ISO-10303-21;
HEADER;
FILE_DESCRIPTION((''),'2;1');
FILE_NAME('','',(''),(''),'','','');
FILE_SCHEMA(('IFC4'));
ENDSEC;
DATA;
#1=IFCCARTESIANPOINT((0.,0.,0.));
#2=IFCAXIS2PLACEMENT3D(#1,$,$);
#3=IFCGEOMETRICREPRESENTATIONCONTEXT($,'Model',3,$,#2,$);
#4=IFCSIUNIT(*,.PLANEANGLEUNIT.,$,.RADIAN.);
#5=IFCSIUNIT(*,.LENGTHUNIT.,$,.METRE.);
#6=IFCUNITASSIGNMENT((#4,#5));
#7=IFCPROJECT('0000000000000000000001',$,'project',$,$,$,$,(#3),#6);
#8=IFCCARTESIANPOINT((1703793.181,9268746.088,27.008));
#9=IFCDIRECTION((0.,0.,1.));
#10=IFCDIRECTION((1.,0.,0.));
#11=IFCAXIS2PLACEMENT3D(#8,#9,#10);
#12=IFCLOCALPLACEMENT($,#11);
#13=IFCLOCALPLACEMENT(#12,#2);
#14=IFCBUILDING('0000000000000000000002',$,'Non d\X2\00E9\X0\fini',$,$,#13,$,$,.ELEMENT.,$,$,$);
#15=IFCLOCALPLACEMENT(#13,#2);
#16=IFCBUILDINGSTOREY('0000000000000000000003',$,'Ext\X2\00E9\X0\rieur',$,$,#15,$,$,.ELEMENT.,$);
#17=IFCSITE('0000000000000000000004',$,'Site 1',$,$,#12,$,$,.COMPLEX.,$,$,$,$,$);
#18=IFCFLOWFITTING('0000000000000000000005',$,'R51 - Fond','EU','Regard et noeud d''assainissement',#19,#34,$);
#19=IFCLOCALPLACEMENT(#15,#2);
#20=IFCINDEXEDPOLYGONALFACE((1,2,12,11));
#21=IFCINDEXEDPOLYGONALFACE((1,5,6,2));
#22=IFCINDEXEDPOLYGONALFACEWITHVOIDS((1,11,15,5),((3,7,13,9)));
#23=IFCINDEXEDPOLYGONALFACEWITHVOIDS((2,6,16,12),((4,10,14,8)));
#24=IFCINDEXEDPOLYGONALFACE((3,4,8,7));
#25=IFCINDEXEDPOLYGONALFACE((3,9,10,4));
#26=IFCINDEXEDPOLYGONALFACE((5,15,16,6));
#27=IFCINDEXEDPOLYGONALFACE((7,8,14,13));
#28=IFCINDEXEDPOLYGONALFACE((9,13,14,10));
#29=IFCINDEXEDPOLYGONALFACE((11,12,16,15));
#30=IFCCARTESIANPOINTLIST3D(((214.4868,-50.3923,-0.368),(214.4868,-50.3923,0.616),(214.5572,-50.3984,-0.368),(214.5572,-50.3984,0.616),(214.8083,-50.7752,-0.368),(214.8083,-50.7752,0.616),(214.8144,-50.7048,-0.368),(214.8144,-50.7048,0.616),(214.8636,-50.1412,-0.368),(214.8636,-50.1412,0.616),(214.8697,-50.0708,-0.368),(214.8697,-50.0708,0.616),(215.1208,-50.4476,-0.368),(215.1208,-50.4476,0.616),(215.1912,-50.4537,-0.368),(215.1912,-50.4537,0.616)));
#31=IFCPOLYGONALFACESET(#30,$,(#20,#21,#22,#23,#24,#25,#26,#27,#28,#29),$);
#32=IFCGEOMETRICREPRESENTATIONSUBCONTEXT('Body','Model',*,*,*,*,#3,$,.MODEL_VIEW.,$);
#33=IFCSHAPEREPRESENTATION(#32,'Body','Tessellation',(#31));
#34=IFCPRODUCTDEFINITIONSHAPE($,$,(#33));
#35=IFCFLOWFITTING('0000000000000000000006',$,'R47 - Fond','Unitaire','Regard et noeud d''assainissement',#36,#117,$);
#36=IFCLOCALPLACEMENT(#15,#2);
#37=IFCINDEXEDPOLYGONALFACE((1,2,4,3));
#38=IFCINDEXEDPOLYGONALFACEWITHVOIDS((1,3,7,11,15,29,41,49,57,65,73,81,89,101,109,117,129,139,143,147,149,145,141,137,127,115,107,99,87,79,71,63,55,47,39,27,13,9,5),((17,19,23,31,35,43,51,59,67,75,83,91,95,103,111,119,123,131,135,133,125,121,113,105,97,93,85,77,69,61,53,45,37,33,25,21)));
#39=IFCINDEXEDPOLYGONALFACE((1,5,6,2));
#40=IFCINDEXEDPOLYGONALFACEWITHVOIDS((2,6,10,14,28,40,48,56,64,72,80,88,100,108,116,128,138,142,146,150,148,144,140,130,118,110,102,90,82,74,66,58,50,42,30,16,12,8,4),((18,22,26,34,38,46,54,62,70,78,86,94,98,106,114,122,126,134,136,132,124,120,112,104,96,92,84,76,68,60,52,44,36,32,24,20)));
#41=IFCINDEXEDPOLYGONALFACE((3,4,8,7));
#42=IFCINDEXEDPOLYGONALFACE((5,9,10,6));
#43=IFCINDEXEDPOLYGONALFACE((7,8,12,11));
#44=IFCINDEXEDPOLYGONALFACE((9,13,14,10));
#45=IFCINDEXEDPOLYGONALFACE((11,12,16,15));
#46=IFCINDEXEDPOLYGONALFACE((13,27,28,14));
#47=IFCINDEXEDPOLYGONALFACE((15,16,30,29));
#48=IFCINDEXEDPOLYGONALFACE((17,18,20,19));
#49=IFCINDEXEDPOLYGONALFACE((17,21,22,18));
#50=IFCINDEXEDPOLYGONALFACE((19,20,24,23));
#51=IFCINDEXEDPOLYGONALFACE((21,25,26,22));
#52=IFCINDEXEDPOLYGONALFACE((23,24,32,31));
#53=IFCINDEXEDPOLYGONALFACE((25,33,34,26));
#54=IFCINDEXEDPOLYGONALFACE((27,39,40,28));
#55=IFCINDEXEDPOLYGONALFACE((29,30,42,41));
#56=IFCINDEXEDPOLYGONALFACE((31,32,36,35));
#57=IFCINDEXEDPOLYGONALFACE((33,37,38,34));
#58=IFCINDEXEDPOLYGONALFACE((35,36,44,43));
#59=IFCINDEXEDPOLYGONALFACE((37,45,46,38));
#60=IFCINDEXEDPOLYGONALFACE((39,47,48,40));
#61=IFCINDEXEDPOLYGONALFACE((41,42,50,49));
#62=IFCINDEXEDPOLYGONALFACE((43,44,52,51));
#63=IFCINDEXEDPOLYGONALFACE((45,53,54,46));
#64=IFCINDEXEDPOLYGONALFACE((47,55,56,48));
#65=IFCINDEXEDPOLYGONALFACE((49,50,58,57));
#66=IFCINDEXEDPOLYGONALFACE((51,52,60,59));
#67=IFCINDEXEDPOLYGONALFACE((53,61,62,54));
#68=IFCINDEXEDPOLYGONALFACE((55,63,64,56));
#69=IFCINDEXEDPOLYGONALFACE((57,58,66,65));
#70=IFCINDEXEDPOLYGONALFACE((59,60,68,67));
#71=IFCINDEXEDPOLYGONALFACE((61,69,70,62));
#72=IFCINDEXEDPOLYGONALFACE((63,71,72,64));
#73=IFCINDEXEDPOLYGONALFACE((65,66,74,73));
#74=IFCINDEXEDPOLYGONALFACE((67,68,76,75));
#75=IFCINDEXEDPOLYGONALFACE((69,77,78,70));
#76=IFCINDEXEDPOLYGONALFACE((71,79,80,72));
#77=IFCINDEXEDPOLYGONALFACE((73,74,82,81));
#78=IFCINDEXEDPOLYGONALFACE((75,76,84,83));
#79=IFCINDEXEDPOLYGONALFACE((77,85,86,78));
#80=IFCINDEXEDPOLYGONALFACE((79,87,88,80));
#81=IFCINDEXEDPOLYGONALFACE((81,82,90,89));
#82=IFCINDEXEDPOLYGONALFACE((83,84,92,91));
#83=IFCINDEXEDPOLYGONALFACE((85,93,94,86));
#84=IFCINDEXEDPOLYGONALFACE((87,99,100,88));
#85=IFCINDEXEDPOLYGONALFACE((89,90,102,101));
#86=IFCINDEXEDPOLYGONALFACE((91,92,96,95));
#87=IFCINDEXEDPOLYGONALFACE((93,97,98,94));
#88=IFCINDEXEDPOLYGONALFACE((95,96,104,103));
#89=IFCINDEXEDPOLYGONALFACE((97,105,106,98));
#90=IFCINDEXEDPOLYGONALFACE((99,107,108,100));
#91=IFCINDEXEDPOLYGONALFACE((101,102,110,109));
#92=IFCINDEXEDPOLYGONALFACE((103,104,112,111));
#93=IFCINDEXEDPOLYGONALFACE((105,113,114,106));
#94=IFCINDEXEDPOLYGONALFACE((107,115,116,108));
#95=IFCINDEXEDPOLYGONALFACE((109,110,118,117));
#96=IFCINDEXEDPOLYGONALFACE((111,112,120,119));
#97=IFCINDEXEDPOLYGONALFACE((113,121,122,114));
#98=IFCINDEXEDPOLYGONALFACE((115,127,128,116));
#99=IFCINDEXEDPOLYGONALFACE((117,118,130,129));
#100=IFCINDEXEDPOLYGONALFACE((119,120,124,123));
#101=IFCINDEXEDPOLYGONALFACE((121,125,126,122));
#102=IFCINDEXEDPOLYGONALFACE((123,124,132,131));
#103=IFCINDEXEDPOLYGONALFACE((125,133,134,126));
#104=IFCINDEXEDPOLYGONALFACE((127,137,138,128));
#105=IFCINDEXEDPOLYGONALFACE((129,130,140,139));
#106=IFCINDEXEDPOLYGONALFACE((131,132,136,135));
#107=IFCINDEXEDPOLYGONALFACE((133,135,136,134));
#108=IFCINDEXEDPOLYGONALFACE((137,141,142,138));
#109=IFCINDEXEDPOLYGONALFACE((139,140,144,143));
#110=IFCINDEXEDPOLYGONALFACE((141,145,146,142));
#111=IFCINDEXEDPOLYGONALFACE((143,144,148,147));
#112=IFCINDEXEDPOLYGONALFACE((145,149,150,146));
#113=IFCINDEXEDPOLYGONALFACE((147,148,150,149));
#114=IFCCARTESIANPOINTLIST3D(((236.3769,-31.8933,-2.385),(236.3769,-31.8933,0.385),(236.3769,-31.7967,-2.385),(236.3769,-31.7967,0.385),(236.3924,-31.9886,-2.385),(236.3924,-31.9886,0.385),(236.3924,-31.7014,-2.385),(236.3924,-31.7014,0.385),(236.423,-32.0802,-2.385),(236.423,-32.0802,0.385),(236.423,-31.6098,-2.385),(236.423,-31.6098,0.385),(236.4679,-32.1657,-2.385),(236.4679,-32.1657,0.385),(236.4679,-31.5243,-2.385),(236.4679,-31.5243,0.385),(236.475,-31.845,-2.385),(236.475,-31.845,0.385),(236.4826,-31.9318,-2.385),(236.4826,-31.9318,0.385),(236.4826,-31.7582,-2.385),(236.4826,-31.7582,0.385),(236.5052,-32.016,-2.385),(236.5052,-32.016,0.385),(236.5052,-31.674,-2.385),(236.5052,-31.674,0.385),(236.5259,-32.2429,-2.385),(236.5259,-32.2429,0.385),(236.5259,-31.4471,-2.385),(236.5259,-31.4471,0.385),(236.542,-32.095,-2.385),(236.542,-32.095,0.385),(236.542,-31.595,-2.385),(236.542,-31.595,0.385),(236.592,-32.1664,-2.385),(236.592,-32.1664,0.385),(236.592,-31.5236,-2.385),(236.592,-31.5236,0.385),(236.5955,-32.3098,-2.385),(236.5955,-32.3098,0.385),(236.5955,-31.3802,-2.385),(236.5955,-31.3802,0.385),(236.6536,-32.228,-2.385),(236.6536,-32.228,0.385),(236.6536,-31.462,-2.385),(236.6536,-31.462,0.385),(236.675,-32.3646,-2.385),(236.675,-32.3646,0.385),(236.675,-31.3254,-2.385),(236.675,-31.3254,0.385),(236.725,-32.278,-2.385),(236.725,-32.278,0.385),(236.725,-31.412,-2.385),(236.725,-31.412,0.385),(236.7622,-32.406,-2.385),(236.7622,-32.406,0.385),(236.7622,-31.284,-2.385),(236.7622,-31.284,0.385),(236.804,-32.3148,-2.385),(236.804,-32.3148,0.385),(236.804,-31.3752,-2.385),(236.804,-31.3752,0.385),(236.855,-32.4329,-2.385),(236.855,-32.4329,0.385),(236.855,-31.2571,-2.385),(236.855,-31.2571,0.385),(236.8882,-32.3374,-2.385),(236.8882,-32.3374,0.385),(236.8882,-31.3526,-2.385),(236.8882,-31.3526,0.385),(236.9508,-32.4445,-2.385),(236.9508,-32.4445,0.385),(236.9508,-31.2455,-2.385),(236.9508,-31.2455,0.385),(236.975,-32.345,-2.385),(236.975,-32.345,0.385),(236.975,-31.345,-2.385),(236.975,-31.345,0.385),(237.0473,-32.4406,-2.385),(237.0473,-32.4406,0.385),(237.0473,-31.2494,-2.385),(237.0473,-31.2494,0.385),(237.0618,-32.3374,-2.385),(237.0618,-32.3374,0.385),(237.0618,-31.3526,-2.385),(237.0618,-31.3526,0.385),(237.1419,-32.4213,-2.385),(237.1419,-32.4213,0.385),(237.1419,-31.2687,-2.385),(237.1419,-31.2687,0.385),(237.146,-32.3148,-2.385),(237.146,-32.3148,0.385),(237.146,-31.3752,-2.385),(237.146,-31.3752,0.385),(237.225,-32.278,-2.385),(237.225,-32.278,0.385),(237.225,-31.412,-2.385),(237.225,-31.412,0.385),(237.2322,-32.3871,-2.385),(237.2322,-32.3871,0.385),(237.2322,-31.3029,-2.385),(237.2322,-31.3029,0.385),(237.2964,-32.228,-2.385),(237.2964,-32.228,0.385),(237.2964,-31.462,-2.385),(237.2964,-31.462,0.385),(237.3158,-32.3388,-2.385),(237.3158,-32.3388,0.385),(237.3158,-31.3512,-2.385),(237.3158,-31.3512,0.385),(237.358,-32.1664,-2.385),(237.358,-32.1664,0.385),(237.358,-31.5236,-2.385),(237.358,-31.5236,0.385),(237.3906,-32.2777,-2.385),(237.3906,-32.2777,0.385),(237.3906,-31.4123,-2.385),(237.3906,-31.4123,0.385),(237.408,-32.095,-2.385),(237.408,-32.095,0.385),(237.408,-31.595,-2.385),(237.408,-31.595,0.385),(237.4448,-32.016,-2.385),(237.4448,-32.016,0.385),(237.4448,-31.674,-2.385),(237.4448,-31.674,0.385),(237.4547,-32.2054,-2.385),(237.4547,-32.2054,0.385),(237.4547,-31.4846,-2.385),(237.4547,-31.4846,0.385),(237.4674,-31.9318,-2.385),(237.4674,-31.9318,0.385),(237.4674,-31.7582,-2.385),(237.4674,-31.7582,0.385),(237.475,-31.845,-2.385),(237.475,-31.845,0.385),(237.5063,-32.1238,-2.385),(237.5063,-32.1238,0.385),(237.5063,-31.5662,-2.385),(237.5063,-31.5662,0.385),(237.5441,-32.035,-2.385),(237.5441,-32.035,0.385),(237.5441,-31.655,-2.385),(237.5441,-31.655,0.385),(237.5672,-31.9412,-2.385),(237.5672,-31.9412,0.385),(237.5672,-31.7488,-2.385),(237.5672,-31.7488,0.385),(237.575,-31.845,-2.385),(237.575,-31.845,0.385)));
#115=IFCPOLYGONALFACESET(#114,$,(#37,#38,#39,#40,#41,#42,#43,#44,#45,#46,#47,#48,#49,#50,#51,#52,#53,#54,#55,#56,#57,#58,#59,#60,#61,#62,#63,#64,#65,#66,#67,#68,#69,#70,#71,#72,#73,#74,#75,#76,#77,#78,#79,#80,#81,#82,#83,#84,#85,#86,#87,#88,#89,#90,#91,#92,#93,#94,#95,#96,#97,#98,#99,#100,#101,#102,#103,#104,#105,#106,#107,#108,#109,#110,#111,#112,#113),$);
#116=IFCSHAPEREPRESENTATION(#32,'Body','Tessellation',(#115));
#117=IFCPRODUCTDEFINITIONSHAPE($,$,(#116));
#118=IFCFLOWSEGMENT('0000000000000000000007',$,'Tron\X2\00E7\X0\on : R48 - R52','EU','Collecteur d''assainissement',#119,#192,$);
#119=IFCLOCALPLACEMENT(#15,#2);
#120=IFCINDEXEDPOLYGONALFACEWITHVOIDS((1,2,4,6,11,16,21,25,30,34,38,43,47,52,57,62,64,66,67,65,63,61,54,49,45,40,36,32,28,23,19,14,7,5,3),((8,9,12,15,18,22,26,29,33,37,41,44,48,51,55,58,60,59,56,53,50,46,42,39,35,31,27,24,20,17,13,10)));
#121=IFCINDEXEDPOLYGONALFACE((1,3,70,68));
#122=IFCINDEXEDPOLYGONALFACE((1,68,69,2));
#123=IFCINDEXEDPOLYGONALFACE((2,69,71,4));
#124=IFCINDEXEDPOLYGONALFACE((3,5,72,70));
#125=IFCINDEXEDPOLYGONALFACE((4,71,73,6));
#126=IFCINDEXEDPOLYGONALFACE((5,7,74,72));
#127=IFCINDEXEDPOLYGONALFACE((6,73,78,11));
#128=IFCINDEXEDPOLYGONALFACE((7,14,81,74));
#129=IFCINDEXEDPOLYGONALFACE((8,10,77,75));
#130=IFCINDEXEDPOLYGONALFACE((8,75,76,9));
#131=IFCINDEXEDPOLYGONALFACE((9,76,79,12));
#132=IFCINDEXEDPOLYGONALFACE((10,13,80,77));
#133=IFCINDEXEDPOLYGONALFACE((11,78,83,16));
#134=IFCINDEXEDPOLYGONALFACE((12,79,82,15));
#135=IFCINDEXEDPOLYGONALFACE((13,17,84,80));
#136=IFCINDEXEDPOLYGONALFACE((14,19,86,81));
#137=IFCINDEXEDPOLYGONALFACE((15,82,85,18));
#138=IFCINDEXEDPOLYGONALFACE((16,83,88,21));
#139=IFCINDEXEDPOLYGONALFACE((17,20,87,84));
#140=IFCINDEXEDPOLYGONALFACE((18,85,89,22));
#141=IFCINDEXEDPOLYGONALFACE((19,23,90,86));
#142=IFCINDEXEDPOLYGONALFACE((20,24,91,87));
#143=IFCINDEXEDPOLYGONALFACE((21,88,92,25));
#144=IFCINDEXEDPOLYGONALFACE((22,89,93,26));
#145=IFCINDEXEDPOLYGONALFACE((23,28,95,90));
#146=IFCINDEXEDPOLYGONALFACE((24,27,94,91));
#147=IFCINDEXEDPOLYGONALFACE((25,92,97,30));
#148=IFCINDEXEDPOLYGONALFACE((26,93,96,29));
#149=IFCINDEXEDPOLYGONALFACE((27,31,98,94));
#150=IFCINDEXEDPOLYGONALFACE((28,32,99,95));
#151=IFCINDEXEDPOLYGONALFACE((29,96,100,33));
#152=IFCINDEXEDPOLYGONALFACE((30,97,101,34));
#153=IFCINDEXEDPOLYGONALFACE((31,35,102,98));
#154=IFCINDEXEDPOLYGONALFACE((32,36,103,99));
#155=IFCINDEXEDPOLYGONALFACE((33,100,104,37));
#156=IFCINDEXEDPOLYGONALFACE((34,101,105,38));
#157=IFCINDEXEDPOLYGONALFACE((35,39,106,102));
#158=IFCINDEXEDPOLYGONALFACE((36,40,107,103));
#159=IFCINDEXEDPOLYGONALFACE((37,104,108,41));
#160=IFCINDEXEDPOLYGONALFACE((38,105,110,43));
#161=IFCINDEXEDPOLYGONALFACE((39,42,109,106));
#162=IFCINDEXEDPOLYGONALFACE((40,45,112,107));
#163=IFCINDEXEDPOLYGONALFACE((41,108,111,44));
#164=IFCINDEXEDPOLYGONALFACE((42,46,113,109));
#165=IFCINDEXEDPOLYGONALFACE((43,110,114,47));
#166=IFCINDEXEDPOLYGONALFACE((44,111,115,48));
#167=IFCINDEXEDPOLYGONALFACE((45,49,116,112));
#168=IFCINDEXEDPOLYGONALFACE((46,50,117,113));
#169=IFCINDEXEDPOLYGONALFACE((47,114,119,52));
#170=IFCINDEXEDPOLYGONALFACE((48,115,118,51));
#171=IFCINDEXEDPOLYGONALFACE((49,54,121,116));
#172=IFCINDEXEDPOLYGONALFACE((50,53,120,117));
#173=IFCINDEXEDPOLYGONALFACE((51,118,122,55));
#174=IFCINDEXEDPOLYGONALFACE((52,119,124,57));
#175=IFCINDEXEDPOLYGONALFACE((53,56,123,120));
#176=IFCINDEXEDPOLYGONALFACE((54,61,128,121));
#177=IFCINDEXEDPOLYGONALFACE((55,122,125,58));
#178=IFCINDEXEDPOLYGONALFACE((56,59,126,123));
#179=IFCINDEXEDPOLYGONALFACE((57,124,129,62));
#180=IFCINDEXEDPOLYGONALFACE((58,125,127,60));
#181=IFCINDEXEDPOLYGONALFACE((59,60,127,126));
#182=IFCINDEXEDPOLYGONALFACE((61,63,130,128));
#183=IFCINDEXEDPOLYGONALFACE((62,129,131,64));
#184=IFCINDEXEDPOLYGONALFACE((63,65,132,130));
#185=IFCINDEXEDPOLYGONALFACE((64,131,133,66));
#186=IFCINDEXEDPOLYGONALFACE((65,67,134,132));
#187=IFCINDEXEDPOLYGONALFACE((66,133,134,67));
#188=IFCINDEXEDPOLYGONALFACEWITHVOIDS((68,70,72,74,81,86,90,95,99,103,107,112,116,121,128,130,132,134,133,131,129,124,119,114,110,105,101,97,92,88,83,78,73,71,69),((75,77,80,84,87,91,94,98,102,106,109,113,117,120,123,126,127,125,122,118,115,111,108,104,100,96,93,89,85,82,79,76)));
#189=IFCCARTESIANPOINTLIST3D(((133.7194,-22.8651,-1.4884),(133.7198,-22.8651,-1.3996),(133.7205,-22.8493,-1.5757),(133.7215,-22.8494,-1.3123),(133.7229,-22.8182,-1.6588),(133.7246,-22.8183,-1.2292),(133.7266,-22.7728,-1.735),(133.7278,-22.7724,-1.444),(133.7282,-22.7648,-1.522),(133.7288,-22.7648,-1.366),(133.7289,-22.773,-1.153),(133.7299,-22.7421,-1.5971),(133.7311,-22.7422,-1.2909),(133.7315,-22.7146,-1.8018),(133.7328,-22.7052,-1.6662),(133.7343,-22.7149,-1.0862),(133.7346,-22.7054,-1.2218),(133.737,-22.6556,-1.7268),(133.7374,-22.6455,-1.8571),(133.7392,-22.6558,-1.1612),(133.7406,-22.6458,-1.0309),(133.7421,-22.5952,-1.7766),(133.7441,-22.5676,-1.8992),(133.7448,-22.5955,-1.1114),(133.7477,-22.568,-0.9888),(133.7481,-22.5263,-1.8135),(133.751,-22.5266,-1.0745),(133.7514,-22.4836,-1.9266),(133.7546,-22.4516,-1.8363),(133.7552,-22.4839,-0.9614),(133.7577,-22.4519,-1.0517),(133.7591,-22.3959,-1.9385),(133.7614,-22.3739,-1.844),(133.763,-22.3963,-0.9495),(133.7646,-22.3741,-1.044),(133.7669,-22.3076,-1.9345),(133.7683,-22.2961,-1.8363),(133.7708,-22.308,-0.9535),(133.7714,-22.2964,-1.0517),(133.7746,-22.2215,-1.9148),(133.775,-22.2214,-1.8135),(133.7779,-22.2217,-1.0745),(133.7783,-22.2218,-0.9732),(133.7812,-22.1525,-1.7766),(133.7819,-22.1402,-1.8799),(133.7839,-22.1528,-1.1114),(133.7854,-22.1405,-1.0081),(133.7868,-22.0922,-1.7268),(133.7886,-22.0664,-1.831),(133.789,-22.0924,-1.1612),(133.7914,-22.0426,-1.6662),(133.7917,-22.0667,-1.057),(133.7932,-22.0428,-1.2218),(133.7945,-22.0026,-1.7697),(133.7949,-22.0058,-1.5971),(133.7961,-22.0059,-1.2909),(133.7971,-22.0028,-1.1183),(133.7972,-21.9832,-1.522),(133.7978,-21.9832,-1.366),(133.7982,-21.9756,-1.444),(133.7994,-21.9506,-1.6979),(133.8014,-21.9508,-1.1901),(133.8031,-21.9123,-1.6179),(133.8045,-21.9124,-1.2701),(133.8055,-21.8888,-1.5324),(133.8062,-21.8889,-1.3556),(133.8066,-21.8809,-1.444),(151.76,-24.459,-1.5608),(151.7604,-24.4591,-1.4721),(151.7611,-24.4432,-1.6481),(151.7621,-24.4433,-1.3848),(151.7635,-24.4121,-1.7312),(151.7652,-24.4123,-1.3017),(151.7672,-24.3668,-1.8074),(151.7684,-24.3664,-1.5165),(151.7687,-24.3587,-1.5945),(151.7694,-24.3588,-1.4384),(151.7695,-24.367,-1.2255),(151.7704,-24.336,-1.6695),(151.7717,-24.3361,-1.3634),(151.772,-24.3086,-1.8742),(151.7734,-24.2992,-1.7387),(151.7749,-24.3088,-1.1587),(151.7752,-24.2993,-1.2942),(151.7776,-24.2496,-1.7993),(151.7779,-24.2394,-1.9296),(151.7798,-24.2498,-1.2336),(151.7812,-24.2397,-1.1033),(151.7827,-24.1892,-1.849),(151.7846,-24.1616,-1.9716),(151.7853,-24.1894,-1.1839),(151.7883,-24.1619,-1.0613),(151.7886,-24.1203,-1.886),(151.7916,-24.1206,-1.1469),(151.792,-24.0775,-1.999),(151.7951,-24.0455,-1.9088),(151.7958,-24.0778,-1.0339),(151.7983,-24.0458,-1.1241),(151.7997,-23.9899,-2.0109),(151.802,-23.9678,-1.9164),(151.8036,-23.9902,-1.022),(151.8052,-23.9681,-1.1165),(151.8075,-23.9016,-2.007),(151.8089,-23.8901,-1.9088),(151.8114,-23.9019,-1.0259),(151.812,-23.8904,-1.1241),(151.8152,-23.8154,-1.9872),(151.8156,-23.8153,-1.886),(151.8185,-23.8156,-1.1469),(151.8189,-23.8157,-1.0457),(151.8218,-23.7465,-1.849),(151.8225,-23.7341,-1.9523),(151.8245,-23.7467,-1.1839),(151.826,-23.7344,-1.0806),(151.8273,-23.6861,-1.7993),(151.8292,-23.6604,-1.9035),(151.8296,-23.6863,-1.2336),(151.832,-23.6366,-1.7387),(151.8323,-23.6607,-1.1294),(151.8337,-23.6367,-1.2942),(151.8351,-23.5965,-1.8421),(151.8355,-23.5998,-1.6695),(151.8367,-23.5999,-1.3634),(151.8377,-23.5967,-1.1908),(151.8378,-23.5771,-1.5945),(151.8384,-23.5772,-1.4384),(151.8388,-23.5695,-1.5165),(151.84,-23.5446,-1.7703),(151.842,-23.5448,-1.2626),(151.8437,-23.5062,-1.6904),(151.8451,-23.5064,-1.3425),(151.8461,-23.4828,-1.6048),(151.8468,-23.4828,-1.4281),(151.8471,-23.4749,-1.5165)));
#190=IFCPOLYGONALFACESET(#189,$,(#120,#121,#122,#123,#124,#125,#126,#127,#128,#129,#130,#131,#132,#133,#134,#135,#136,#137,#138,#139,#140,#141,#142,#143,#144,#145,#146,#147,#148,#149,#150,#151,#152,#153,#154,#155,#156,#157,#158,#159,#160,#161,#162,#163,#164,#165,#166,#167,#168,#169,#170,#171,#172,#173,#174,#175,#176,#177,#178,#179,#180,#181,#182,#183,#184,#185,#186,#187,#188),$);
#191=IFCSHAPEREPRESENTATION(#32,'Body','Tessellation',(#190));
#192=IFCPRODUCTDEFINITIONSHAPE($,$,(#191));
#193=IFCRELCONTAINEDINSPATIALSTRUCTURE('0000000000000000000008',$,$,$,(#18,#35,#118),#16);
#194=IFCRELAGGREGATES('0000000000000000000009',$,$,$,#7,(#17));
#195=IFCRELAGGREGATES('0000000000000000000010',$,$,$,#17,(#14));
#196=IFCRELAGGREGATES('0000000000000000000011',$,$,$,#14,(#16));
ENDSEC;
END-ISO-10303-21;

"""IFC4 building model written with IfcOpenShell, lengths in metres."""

from ifc_helpers import new_model, si_unit, frame, origin, origin_2d, place, context, subcontext, project, spatial, hollow_rectangle, hollow_circle, extrude, element, save


model = new_model("IFC4")

# Units and contexts
model_context = context("Model", 3, world=origin())
body_context = subcontext(model_context, "Body", "Model", "MODEL_VIEW")
ifc_project = project(units=[si_unit("PLANEANGLEUNIT", "RADIAN"), si_unit("LENGTHUNIT", "METRE")], contexts=[model_context])

# Site, building, storey
site_placement = place(None, frame((1703793.181, 9268746.088, 27.008), z_axis=(0.0, 0.0, 1.0), x_axis=(1.0, 0.0, 0.0)))
site = spatial("IfcSite", under=ifc_project, at=site_placement, Name="Site 1", CompositionType="COMPLEX")
building_placement = place(site_placement, origin())
building = spatial("IfcBuilding", under=site, at=building_placement, Name="Non défini", CompositionType="ELEMENT")
storey_placement = place(building_placement, origin())
storey = spatial("IfcBuildingStorey", under=building, at=storey_placement, Name="Extérieur", CompositionType="ELEMENT")

# Flow fittings
flow_fitting_1_placement = place(storey_placement, origin())
element("IfcFlowFitting", 1, at=flow_fitting_1_placement, inside=storey, Name="R51 - Fond", Description="EU", ObjectType="Regard et noeud d'assainissement", context=body_context, shape_type="SweptSolid", body=[
    extrude(hollow_rectangle(XDim=0.5, YDim=0.5, WallThickness=0.05, at=origin_2d()), frame((214.839, -50.423, -0.368), z_axis=(0.0, 0.0, 1.0), x_axis=(0.766, 0.643, 0.0)), (0.0, 0.0, 1.0), 0.984),
])
flow_fitting_2_placement = place(storey_placement, origin())
element("IfcFlowFitting", 2, at=flow_fitting_2_placement, inside=storey, Name="R47 - Fond", Description="Unitaire", ObjectType="Regard et noeud d'assainissement", context=body_context, shape_type="SweptSolid", body=[
    extrude(hollow_circle(Radius=0.6, WallThickness=0.1, at=origin_2d()), frame((236.975, -31.845, -2.385), z_axis=(0.0, 0.0, 1.0), x_axis=(1.0, 0.0, 0.0)), (0.0, 0.0, 1.0), 2.77),
])

# Flow segment
flow_segment_1_placement = place(storey_placement, origin())
element("IfcFlowSegment", 3, at=flow_segment_1_placement, inside=storey, Name="Tronçon : R48 - R52", Description="EU", ObjectType="Collecteur d'assainissement", context=body_context, shape_type="SweptSolid", body=[
    extrude(hollow_circle(Radius=0.495, WallThickness=0.095, at=origin_2d()), frame((133.763, -22.374, -1.444), z_axis=(0.996, -0.088, -0.004), x_axis=(0.088, 0.996, 0.0)), (0.0, 0.0, 1.0), 18.111),
])

save(model, "model.ifc")
